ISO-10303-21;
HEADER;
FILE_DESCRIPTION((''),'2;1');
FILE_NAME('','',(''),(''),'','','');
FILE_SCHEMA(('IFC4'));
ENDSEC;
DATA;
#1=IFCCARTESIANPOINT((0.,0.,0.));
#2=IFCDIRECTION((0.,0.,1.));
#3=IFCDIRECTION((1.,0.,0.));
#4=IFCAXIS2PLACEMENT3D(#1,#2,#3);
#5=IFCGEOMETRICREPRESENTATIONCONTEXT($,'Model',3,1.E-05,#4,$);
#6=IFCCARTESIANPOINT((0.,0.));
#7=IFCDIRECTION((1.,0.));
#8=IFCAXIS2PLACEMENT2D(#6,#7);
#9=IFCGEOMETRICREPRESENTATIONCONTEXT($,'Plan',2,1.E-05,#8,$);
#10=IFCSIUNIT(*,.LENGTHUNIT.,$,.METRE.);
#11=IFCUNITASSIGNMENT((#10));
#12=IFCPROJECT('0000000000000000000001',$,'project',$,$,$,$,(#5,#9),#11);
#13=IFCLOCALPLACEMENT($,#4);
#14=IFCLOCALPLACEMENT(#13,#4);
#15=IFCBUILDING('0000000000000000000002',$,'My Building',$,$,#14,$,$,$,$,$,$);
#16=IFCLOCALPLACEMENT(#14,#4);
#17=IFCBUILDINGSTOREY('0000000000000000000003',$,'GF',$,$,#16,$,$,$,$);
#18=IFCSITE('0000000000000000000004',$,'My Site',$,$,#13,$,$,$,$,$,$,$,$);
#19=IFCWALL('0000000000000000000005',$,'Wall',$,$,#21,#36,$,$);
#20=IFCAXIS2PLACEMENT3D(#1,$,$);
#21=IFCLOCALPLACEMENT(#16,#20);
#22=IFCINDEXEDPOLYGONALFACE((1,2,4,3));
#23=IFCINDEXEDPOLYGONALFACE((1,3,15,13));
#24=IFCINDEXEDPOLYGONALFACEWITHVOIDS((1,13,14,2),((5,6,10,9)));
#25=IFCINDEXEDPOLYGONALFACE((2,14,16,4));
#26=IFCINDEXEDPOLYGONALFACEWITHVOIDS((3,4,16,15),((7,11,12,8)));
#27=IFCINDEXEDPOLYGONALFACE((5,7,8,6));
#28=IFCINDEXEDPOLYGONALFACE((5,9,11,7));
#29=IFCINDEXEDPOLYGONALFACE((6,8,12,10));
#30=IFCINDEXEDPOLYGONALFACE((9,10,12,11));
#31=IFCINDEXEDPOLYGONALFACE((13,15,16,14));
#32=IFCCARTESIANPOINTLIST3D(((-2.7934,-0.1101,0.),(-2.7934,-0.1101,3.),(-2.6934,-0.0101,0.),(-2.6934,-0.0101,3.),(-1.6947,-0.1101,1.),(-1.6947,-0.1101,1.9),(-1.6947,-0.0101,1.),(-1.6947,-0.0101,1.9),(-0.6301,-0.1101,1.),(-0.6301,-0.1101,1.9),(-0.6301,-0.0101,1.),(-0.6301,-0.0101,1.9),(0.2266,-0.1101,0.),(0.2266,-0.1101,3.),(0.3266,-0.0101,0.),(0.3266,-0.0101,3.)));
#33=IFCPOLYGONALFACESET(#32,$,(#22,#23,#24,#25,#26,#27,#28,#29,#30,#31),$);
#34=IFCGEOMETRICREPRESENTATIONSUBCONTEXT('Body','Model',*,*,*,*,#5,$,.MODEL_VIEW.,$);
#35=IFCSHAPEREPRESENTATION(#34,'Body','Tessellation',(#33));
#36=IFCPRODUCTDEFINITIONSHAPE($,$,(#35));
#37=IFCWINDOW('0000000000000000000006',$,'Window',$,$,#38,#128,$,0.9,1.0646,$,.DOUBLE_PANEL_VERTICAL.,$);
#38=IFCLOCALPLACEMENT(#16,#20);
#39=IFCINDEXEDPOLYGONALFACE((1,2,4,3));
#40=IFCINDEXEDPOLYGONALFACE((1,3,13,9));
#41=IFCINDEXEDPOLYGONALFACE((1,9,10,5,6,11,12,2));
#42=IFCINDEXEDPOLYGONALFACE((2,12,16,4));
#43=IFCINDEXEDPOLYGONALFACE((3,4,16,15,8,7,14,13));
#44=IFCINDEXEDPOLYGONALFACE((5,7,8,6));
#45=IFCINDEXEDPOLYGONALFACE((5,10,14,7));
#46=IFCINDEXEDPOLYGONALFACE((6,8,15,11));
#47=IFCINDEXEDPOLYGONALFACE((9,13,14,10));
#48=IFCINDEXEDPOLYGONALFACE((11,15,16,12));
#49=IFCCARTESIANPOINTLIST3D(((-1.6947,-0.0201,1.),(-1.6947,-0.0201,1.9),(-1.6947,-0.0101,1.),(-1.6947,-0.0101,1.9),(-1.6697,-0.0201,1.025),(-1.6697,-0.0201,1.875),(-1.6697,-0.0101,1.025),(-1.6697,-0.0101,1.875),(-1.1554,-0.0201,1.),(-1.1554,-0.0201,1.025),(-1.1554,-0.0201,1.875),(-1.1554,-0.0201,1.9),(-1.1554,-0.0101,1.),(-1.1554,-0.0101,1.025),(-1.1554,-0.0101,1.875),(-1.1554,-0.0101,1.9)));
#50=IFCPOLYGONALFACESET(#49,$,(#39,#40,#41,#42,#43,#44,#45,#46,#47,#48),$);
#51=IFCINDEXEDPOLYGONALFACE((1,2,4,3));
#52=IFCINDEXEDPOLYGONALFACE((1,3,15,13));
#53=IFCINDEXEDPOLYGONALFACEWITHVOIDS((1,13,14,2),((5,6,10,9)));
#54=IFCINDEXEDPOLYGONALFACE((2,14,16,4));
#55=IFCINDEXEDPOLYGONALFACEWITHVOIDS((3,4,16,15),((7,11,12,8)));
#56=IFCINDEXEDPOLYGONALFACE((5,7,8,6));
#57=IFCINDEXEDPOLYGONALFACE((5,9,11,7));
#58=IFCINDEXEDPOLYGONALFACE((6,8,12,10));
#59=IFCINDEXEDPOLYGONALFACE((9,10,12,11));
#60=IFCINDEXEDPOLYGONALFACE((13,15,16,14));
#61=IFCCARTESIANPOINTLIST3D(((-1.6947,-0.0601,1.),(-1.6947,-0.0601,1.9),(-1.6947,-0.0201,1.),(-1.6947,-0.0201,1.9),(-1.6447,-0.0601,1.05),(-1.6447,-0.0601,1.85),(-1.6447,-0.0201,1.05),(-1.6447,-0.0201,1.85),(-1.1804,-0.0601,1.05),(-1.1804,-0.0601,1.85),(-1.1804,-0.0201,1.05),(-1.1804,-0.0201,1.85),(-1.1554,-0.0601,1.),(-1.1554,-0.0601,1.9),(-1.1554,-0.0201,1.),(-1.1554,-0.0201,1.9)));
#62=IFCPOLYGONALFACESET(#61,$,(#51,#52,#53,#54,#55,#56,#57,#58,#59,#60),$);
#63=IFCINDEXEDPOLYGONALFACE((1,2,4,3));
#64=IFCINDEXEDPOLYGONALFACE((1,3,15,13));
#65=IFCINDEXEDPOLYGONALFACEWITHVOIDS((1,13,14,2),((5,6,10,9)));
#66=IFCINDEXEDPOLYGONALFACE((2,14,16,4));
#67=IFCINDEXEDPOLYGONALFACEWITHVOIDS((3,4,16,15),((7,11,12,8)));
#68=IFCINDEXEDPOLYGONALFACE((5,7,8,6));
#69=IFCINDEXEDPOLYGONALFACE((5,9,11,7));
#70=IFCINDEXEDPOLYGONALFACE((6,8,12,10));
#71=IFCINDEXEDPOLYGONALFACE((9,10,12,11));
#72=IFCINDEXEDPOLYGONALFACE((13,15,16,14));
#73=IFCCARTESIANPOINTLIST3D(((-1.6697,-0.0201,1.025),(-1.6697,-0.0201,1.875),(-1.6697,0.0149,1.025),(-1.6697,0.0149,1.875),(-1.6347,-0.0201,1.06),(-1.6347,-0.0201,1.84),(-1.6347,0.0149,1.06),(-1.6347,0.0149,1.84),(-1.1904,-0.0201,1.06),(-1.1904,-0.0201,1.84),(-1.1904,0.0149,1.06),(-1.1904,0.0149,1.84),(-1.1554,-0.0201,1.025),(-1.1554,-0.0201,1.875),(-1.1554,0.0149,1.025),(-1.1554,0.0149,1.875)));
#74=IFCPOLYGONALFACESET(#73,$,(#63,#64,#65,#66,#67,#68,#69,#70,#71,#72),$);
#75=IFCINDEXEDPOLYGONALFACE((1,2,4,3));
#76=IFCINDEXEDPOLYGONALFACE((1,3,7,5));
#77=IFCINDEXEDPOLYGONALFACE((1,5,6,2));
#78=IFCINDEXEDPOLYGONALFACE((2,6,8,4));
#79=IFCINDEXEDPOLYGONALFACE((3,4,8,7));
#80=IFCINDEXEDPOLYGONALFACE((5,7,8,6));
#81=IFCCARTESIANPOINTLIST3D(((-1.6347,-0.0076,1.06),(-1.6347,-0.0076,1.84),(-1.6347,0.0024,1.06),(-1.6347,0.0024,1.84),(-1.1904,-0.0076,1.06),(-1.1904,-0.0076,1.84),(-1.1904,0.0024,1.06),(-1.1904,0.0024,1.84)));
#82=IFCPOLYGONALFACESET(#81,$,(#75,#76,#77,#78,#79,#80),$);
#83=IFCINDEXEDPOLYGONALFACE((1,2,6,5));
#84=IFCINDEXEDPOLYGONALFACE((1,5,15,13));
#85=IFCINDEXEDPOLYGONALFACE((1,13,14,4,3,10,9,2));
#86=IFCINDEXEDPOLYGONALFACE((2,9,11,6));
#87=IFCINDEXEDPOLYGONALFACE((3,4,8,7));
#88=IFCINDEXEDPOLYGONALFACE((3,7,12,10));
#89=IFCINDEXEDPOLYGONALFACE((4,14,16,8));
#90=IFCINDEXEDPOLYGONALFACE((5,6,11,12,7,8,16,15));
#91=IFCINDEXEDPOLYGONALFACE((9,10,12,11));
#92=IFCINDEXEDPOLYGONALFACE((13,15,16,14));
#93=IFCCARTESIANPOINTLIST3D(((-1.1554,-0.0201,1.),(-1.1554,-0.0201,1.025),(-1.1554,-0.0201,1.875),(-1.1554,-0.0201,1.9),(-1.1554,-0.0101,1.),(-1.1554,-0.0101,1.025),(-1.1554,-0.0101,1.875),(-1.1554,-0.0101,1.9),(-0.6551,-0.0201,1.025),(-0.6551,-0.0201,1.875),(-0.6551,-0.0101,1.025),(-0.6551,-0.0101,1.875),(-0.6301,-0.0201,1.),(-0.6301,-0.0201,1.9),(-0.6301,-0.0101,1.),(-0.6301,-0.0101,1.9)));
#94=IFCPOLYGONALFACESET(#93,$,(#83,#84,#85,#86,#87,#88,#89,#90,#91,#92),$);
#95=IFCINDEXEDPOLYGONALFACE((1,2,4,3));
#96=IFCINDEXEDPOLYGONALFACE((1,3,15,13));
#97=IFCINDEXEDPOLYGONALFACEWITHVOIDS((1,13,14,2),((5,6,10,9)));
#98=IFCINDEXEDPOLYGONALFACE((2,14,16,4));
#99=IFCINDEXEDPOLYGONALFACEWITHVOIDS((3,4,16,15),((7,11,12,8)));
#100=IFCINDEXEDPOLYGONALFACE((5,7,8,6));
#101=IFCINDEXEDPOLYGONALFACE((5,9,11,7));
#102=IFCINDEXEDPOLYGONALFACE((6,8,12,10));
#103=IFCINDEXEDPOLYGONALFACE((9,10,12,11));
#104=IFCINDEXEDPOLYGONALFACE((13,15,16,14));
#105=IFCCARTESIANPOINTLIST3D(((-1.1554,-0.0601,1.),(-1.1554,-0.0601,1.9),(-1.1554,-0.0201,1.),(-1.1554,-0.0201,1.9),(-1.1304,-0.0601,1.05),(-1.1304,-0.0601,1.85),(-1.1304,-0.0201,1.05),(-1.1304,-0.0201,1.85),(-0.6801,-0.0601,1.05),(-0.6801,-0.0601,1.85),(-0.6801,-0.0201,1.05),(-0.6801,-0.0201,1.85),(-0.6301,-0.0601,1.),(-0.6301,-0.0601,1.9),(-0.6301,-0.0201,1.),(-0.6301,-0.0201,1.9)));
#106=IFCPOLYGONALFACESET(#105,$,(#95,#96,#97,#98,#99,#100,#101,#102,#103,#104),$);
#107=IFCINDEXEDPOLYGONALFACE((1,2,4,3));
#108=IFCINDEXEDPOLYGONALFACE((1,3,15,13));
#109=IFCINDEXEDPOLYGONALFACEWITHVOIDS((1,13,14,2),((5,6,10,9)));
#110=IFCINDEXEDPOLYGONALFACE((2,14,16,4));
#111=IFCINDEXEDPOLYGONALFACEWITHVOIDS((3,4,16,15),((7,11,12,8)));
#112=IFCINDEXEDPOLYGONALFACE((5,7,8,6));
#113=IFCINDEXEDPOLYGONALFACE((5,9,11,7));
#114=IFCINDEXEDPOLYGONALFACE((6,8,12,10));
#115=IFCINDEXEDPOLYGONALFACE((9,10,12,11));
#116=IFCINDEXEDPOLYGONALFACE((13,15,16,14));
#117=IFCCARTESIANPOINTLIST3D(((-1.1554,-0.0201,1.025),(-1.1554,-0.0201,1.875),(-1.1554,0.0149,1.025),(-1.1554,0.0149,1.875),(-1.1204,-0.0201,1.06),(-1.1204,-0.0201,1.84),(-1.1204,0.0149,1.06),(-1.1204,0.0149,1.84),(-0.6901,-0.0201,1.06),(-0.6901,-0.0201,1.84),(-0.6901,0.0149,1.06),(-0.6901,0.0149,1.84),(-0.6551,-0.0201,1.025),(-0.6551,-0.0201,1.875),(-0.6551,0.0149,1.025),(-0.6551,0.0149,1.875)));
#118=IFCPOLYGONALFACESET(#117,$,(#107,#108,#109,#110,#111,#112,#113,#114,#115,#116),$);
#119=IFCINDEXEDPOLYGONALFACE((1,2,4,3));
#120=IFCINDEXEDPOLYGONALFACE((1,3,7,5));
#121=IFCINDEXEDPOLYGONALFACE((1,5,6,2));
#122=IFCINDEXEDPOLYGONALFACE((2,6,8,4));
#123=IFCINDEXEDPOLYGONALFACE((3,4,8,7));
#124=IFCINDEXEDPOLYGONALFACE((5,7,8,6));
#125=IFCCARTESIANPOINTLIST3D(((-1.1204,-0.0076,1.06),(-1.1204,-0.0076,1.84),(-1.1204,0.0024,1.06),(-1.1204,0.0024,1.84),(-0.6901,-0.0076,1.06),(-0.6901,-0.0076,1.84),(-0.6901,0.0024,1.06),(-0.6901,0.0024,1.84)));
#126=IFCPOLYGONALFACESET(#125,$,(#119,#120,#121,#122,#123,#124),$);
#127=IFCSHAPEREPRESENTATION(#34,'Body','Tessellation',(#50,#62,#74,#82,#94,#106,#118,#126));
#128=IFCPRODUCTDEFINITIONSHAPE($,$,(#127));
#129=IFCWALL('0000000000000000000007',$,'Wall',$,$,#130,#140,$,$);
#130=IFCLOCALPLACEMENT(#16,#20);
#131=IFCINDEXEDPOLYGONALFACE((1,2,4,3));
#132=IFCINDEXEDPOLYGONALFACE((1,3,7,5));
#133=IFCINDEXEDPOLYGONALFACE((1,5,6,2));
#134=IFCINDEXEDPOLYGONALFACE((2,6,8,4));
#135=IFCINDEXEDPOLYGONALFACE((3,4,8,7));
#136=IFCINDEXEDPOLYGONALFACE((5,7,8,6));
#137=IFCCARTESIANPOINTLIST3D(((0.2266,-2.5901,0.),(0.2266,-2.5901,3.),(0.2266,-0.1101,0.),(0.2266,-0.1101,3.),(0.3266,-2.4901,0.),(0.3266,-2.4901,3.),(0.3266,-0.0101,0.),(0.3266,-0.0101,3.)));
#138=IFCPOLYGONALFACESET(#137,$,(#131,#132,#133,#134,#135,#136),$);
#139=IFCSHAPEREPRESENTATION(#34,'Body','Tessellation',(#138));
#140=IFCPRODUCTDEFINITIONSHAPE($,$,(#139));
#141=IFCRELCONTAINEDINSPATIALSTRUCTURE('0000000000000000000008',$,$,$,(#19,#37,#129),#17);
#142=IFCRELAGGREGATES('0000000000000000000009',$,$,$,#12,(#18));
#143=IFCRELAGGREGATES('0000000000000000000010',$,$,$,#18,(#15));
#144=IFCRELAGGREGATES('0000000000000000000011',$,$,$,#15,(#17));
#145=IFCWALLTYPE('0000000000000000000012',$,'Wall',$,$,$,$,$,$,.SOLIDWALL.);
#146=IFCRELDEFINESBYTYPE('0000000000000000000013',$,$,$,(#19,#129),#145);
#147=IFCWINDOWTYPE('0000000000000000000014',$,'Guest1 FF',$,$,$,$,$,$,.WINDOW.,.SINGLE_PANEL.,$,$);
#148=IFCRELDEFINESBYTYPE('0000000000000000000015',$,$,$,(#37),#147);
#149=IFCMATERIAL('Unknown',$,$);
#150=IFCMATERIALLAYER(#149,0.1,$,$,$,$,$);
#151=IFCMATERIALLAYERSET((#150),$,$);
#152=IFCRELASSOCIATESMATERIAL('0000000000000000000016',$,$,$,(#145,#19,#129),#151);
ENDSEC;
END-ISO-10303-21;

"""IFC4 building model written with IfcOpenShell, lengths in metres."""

from ifc_helpers import new_model, entity, si_unit, frame, origin_with_axes, origin_2d_with_axis, place, context, subcontext, project, spatial, line, indexed_curve, outline, extrude, shape, source, transform, mapped, material, layer, layer_set, layer_usage, type_object, type_shapes, element, fill, save


model = new_model("IFC4")

# Units and contexts
model_context = context("Model", 3, precision=1e-05, world=origin_with_axes())
plan_context = context("Plan", 2, precision=1e-05, world=origin_2d_with_axis())
body_context_1 = subcontext(model_context, "Body", "Model", "MODEL_VIEW")
body_context_2 = subcontext(plan_context, "Body", "Plan", "PLAN_VIEW")
ifc_project = project(units=[si_unit("LENGTHUNIT", "METRE")], contexts=[model_context, plan_context])

# Site, building, storey
site_placement = place(None, origin_with_axes())
site = spatial("IfcSite", under=ifc_project, at=site_placement, Name="My Site")
building_placement = place(site_placement, origin_with_axes())
building = spatial("IfcBuilding", under=site, at=building_placement, Name="My Building")
storey_placement = place(building_placement, origin_with_axes())
storey = spatial("IfcBuildingStorey", under=building, at=storey_placement, Name="GF")

# Shared definitions
ifc_material = material(Name="Unknown")

# Shared definitions
ifc_layer_1 = layer(ifc_material, 0.1)
ifc_layer_set_1 = layer_set([ifc_layer_1])
wall_type = type_object("IfcWallType", Name="Wall", PredefinedType="SOLIDWALL", material=ifc_layer_set_1)

# Wall, opening, window
ifc_layer_usage_1 = layer_usage(ifc_layer_set_1, "AXIS2", "POSITIVE", 0.0)
wall_1_placement = place(storey_placement, frame((-2.7934, -0.1101, 0.0), z_axis=(0.0, 0.0, 1.0), x_axis=(1.0, 0.0, 0.0)))
wall_1 = element("IfcWall", 1, at=wall_1_placement, inside=storey, type_object=wall_type, material=ifc_layer_usage_1, Name="Wall", context=body_context_1, shape_type="SweptSolid", body=[
    extrude(outline(indexed_curve([(0.0, 0.0), (0.1, 0.1), (3.12, 0.1), (3.02, 0.0)], segments=[line(1, 2, 3, 4, 1)])), origin_with_axes(), (0.0, 0.0, 1.0), 3.0),
])
shared_shape_1 = source(origin_with_axes(), body_context_1, "Body", "SweptSolid", [
    extrude(outline(indexed_curve([(0.0, 0.0), (1.0646, 0.0), (1.0646, 0.9), (0.0, 0.9)], segments=[line(1, 2, 3, 4, 1)])), frame((0.0, -0.6, 0.0), z_axis=(0.0, -1.0, 0.0), x_axis=(1.0, 0.0, 0.0)), (0.0, 0.0, -1.0), 1.2),
])
opening_1_placement = place(wall_1_placement, frame((1.0987, 0.0, 1.0), z_axis=(0.0, 0.0, 1.0), x_axis=(1.0, 0.0, 0.0)))
opening_1 = element("IfcOpeningElement", 2, at=opening_1_placement, cuts=wall_1, PredefinedType="OPENING", context=body_context_1, shape_type="MappedRepresentation", body=[
    mapped(shared_shape_1, transform((0.0, 0.0, 0.0), x_axis=(1.0, 0.0, 0.0), y_axis=(0.0, 1.0, 0.0), z_axis=(0.0, 0.0, 1.0), scale=1.0)),
])
window_type_1 = type_object("IfcWindowType", Name="Guest1 FF", PartitioningType="SINGLE_PANEL", PredefinedType="WINDOW")
shared_shape_2 = source(origin_with_axes(), body_context_1, "Body", "SweptSolid", [
    extrude(outline(indexed_curve([(0.5393, 0.0), (0.0, 0.0), (0.0, 0.9), (0.5393, 0.9), (0.5393, 0.875), (0.025, 0.875), (0.025, 0.025), (0.5393, 0.025)], segments=[line(1, 2, 3, 4, 5, 6, 7, 8, 1)])), frame((0.0, 0.09, 0.0), z_axis=(0.0, -1.0, 0.0), x_axis=(1.0, 0.0, 0.0)), (0.0, 0.0, -1.0), 0.01),
    extrude(outline(indexed_curve([(0.0, 0.0), (0.5393, 0.0), (0.5393, 0.9), (0.0, 0.9)], segments=[line(1, 2, 3, 4, 1)]), holes=[indexed_curve([(0.05, 0.05), (0.5143, 0.05), (0.5143, 0.85), (0.05, 0.85)], segments=[line(1, 2, 3, 4, 1)])]), frame((0.0, 0.05, 0.0), z_axis=(0.0, -1.0, 0.0), x_axis=(1.0, 0.0, 0.0)), (0.0, 0.0, -1.0), 0.04),
    extrude(outline(indexed_curve([(0.0, 0.0), (0.5143, 0.0), (0.5143, 0.85), (0.0, 0.85)], segments=[line(1, 2, 3, 4, 1)]), holes=[indexed_curve([(0.035, 0.035), (0.4793, 0.035), (0.4793, 0.815), (0.035, 0.815)], segments=[line(1, 2, 3, 4, 1)])]), frame((0.025, 0.09, 0.025), z_axis=(0.0, -1.0, 0.0), x_axis=(1.0, 0.0, 0.0)), (0.0, 0.0, -1.0), 0.035),
    extrude(outline(indexed_curve([(0.035, 0.035), (0.4793, 0.035), (0.4793, 0.815), (0.035, 0.815)], segments=[line(1, 2, 3, 4, 1)])), frame((0.025, 0.1025, 0.025), z_axis=(0.0, -1.0, 0.0), x_axis=(1.0, 0.0, 0.0)), (0.0, 0.0, -1.0), 0.01),
    extrude(outline(indexed_curve([(0.0, 0.9), (0.5253, 0.9), (0.5253, 0.0), (0.0, 0.0), (0.0, 0.025), (0.5003, 0.025), (0.5003, 0.875), (0.0, 0.875)], segments=[line(1, 2, 3, 4, 5, 6, 7, 8, 1)])), frame((0.5393, 0.09, 0.0), z_axis=(0.0, -1.0, 0.0), x_axis=(1.0, 0.0, 0.0)), (0.0, 0.0, -1.0), 0.01),
    extrude(outline(indexed_curve([(0.0, 0.0), (0.5253, 0.0), (0.5253, 0.9), (0.0, 0.9)], segments=[line(1, 2, 3, 4, 1)]), holes=[indexed_curve([(0.025, 0.05), (0.4753, 0.05), (0.4753, 0.85), (0.025, 0.85)], segments=[line(1, 2, 3, 4, 1)])]), frame((0.5393, 0.05, 0.0), z_axis=(0.0, -1.0, 0.0), x_axis=(1.0, 0.0, 0.0)), (0.0, 0.0, -1.0), 0.04),
    extrude(outline(indexed_curve([(0.0, 0.0), (0.5003, 0.0), (0.5003, 0.85), (0.0, 0.85)], segments=[line(1, 2, 3, 4, 1)]), holes=[indexed_curve([(0.035, 0.035), (0.4653, 0.035), (0.4653, 0.815), (0.035, 0.815)], segments=[line(1, 2, 3, 4, 1)])]), frame((0.5393, 0.09, 0.025), z_axis=(0.0, -1.0, 0.0), x_axis=(1.0, 0.0, 0.0)), (0.0, 0.0, -1.0), 0.035),
    extrude(outline(indexed_curve([(0.035, 0.035), (0.4653, 0.035), (0.4653, 0.815), (0.035, 0.815)], segments=[line(1, 2, 3, 4, 1)])), frame((0.5393, 0.1025, 0.025), z_axis=(0.0, -1.0, 0.0), x_axis=(1.0, 0.0, 0.0)), (0.0, 0.0, -1.0), 0.01),
])
shared_shape_3 = source(origin_with_axes(), body_context_2, "Body", "Curve2D", [
    entity("IfcIndexedPolyCurve", entity("IfcCartesianPointList2D", [[0.05, 0.05], [0.5143, 0.05]])),
    entity("IfcIndexedPolyCurve", entity("IfcCartesianPointList2D", [[0.0, 0.1], [0.025, 0.1], [0.025, 0.09], [0.05, 0.09], [0.05, 0.05], [0.0, 0.05]]), [entity("IfcLineIndex", [1, 2, 3, 4, 5, 6, 1])]),
    entity("IfcIndexedPolyCurve", entity("IfcCartesianPointList2D", [[0.5393, 0.1], [0.5393, 0.1], [0.5393, 0.09], [0.5143, 0.09], [0.5143, 0.05], [0.5393, 0.05]])),
    entity("IfcIndexedPolyCurve", entity("IfcCartesianPointList2D", [[0.025, 0.09], [0.06, 0.09], [0.06, 0.125], [0.025, 0.125]]), [entity("IfcLineIndex", [1, 2, 3, 4, 1])]),
    entity("IfcIndexedPolyCurve", entity("IfcCartesianPointList2D", [[0.5393, 0.09], [0.5043, 0.09], [0.5043, 0.125], [0.5393, 0.125]]), [entity("IfcLineIndex", [1, 2, 3, 4, 1])]),
    entity("IfcIndexedPolyCurve", entity("IfcCartesianPointList2D", [[0.06, 0.09], [0.5043, 0.09]])),
    entity("IfcIndexedPolyCurve", entity("IfcCartesianPointList2D", [[0.06, 0.125], [0.5043, 0.125]])),
    entity("IfcIndexedPolyCurve", entity("IfcCartesianPointList2D", [[0.06, 0.1075], [0.5043, 0.1075]])),
    entity("IfcIndexedPolyCurve", entity("IfcCartesianPointList2D", [[0.5643, 0.05], [1.0146, 0.05]])),
    entity("IfcIndexedPolyCurve", entity("IfcCartesianPointList2D", [[0.5393, 0.1], [0.5393, 0.1], [0.5393, 0.09], [0.5643, 0.09], [0.5643, 0.05], [0.5393, 0.05]])),
    entity("IfcIndexedPolyCurve", entity("IfcCartesianPointList2D", [[1.0646, 0.1], [1.0396, 0.1], [1.0396, 0.09], [1.0146, 0.09], [1.0146, 0.05], [1.0646, 0.05]]), [entity("IfcLineIndex", [1, 2, 3, 4, 5, 6, 1])]),
    entity("IfcIndexedPolyCurve", entity("IfcCartesianPointList2D", [[0.5393, 0.09], [0.5743, 0.09], [0.5743, 0.125], [0.5393, 0.125]]), [entity("IfcLineIndex", [1, 2, 3, 4, 1])]),
    entity("IfcIndexedPolyCurve", entity("IfcCartesianPointList2D", [[1.0396, 0.09], [1.0046, 0.09], [1.0046, 0.125], [1.0396, 0.125]]), [entity("IfcLineIndex", [1, 2, 3, 4, 1])]),
    entity("IfcIndexedPolyCurve", entity("IfcCartesianPointList2D", [[0.5743, 0.09], [1.0046, 0.09]])),
    entity("IfcIndexedPolyCurve", entity("IfcCartesianPointList2D", [[0.5743, 0.125], [1.0046, 0.125]])),
    entity("IfcIndexedPolyCurve", entity("IfcCartesianPointList2D", [[0.5743, 0.1075], [1.0046, 0.1075]])),
])
type_shapes(window_type_1, [shared_shape_2, shared_shape_3])
window_1_placement = place(opening_1_placement, origin_with_axes())
window_1 = element("IfcWindow", 3, at=window_1_placement, inside=storey, type_object=window_type_1, Name="Window", OverallHeight=0.9, OverallWidth=1.0646, PartitioningType="DOUBLE_PANEL_VERTICAL", shapes=[
    shape(body_context_1, "Body", "MappedRepresentation", [mapped(shared_shape_2, transform((0.0, 0.0, 0.0), x_axis=(1.0, 0.0, 0.0), y_axis=(0.0, 1.0, 0.0), z_axis=(0.0, 0.0, 1.0), scale=1.0))]),
    shape(body_context_2, "Body", "MappedRepresentation", [mapped(shared_shape_3, transform((0.0, 0.0, 0.0), x_axis=(1.0, 0.0, 0.0), y_axis=(0.0, 1.0, 0.0), z_axis=(0.0, 0.0, 1.0), scale=1.0))]),
])
fill(opening_1, window_1)

# Wall
ifc_layer_usage_2 = layer_usage(ifc_layer_set_1, "AXIS2", "POSITIVE", 0.0)
wall_2_placement = place(storey_placement, frame((0.2266, -0.1101, 0.0), z_axis=(0.0, 0.0, 1.0), x_axis=(0.0, -1.0, 0.0)))
element("IfcWall", 4, at=wall_2_placement, inside=storey, type_object=wall_type, material=ifc_layer_usage_2, Name="Wall", context=body_context_1, shape_type="SweptSolid", body=[
    extrude(outline(indexed_curve([(0.0, 0.0), (-0.1, 0.1), (2.38, 0.1), (2.48, 0.0)], segments=[line(1, 2, 3, 4, 1)])), origin_with_axes(), (0.0, 0.0, 1.0), 3.0),
])

save(model, "model.ifc")
